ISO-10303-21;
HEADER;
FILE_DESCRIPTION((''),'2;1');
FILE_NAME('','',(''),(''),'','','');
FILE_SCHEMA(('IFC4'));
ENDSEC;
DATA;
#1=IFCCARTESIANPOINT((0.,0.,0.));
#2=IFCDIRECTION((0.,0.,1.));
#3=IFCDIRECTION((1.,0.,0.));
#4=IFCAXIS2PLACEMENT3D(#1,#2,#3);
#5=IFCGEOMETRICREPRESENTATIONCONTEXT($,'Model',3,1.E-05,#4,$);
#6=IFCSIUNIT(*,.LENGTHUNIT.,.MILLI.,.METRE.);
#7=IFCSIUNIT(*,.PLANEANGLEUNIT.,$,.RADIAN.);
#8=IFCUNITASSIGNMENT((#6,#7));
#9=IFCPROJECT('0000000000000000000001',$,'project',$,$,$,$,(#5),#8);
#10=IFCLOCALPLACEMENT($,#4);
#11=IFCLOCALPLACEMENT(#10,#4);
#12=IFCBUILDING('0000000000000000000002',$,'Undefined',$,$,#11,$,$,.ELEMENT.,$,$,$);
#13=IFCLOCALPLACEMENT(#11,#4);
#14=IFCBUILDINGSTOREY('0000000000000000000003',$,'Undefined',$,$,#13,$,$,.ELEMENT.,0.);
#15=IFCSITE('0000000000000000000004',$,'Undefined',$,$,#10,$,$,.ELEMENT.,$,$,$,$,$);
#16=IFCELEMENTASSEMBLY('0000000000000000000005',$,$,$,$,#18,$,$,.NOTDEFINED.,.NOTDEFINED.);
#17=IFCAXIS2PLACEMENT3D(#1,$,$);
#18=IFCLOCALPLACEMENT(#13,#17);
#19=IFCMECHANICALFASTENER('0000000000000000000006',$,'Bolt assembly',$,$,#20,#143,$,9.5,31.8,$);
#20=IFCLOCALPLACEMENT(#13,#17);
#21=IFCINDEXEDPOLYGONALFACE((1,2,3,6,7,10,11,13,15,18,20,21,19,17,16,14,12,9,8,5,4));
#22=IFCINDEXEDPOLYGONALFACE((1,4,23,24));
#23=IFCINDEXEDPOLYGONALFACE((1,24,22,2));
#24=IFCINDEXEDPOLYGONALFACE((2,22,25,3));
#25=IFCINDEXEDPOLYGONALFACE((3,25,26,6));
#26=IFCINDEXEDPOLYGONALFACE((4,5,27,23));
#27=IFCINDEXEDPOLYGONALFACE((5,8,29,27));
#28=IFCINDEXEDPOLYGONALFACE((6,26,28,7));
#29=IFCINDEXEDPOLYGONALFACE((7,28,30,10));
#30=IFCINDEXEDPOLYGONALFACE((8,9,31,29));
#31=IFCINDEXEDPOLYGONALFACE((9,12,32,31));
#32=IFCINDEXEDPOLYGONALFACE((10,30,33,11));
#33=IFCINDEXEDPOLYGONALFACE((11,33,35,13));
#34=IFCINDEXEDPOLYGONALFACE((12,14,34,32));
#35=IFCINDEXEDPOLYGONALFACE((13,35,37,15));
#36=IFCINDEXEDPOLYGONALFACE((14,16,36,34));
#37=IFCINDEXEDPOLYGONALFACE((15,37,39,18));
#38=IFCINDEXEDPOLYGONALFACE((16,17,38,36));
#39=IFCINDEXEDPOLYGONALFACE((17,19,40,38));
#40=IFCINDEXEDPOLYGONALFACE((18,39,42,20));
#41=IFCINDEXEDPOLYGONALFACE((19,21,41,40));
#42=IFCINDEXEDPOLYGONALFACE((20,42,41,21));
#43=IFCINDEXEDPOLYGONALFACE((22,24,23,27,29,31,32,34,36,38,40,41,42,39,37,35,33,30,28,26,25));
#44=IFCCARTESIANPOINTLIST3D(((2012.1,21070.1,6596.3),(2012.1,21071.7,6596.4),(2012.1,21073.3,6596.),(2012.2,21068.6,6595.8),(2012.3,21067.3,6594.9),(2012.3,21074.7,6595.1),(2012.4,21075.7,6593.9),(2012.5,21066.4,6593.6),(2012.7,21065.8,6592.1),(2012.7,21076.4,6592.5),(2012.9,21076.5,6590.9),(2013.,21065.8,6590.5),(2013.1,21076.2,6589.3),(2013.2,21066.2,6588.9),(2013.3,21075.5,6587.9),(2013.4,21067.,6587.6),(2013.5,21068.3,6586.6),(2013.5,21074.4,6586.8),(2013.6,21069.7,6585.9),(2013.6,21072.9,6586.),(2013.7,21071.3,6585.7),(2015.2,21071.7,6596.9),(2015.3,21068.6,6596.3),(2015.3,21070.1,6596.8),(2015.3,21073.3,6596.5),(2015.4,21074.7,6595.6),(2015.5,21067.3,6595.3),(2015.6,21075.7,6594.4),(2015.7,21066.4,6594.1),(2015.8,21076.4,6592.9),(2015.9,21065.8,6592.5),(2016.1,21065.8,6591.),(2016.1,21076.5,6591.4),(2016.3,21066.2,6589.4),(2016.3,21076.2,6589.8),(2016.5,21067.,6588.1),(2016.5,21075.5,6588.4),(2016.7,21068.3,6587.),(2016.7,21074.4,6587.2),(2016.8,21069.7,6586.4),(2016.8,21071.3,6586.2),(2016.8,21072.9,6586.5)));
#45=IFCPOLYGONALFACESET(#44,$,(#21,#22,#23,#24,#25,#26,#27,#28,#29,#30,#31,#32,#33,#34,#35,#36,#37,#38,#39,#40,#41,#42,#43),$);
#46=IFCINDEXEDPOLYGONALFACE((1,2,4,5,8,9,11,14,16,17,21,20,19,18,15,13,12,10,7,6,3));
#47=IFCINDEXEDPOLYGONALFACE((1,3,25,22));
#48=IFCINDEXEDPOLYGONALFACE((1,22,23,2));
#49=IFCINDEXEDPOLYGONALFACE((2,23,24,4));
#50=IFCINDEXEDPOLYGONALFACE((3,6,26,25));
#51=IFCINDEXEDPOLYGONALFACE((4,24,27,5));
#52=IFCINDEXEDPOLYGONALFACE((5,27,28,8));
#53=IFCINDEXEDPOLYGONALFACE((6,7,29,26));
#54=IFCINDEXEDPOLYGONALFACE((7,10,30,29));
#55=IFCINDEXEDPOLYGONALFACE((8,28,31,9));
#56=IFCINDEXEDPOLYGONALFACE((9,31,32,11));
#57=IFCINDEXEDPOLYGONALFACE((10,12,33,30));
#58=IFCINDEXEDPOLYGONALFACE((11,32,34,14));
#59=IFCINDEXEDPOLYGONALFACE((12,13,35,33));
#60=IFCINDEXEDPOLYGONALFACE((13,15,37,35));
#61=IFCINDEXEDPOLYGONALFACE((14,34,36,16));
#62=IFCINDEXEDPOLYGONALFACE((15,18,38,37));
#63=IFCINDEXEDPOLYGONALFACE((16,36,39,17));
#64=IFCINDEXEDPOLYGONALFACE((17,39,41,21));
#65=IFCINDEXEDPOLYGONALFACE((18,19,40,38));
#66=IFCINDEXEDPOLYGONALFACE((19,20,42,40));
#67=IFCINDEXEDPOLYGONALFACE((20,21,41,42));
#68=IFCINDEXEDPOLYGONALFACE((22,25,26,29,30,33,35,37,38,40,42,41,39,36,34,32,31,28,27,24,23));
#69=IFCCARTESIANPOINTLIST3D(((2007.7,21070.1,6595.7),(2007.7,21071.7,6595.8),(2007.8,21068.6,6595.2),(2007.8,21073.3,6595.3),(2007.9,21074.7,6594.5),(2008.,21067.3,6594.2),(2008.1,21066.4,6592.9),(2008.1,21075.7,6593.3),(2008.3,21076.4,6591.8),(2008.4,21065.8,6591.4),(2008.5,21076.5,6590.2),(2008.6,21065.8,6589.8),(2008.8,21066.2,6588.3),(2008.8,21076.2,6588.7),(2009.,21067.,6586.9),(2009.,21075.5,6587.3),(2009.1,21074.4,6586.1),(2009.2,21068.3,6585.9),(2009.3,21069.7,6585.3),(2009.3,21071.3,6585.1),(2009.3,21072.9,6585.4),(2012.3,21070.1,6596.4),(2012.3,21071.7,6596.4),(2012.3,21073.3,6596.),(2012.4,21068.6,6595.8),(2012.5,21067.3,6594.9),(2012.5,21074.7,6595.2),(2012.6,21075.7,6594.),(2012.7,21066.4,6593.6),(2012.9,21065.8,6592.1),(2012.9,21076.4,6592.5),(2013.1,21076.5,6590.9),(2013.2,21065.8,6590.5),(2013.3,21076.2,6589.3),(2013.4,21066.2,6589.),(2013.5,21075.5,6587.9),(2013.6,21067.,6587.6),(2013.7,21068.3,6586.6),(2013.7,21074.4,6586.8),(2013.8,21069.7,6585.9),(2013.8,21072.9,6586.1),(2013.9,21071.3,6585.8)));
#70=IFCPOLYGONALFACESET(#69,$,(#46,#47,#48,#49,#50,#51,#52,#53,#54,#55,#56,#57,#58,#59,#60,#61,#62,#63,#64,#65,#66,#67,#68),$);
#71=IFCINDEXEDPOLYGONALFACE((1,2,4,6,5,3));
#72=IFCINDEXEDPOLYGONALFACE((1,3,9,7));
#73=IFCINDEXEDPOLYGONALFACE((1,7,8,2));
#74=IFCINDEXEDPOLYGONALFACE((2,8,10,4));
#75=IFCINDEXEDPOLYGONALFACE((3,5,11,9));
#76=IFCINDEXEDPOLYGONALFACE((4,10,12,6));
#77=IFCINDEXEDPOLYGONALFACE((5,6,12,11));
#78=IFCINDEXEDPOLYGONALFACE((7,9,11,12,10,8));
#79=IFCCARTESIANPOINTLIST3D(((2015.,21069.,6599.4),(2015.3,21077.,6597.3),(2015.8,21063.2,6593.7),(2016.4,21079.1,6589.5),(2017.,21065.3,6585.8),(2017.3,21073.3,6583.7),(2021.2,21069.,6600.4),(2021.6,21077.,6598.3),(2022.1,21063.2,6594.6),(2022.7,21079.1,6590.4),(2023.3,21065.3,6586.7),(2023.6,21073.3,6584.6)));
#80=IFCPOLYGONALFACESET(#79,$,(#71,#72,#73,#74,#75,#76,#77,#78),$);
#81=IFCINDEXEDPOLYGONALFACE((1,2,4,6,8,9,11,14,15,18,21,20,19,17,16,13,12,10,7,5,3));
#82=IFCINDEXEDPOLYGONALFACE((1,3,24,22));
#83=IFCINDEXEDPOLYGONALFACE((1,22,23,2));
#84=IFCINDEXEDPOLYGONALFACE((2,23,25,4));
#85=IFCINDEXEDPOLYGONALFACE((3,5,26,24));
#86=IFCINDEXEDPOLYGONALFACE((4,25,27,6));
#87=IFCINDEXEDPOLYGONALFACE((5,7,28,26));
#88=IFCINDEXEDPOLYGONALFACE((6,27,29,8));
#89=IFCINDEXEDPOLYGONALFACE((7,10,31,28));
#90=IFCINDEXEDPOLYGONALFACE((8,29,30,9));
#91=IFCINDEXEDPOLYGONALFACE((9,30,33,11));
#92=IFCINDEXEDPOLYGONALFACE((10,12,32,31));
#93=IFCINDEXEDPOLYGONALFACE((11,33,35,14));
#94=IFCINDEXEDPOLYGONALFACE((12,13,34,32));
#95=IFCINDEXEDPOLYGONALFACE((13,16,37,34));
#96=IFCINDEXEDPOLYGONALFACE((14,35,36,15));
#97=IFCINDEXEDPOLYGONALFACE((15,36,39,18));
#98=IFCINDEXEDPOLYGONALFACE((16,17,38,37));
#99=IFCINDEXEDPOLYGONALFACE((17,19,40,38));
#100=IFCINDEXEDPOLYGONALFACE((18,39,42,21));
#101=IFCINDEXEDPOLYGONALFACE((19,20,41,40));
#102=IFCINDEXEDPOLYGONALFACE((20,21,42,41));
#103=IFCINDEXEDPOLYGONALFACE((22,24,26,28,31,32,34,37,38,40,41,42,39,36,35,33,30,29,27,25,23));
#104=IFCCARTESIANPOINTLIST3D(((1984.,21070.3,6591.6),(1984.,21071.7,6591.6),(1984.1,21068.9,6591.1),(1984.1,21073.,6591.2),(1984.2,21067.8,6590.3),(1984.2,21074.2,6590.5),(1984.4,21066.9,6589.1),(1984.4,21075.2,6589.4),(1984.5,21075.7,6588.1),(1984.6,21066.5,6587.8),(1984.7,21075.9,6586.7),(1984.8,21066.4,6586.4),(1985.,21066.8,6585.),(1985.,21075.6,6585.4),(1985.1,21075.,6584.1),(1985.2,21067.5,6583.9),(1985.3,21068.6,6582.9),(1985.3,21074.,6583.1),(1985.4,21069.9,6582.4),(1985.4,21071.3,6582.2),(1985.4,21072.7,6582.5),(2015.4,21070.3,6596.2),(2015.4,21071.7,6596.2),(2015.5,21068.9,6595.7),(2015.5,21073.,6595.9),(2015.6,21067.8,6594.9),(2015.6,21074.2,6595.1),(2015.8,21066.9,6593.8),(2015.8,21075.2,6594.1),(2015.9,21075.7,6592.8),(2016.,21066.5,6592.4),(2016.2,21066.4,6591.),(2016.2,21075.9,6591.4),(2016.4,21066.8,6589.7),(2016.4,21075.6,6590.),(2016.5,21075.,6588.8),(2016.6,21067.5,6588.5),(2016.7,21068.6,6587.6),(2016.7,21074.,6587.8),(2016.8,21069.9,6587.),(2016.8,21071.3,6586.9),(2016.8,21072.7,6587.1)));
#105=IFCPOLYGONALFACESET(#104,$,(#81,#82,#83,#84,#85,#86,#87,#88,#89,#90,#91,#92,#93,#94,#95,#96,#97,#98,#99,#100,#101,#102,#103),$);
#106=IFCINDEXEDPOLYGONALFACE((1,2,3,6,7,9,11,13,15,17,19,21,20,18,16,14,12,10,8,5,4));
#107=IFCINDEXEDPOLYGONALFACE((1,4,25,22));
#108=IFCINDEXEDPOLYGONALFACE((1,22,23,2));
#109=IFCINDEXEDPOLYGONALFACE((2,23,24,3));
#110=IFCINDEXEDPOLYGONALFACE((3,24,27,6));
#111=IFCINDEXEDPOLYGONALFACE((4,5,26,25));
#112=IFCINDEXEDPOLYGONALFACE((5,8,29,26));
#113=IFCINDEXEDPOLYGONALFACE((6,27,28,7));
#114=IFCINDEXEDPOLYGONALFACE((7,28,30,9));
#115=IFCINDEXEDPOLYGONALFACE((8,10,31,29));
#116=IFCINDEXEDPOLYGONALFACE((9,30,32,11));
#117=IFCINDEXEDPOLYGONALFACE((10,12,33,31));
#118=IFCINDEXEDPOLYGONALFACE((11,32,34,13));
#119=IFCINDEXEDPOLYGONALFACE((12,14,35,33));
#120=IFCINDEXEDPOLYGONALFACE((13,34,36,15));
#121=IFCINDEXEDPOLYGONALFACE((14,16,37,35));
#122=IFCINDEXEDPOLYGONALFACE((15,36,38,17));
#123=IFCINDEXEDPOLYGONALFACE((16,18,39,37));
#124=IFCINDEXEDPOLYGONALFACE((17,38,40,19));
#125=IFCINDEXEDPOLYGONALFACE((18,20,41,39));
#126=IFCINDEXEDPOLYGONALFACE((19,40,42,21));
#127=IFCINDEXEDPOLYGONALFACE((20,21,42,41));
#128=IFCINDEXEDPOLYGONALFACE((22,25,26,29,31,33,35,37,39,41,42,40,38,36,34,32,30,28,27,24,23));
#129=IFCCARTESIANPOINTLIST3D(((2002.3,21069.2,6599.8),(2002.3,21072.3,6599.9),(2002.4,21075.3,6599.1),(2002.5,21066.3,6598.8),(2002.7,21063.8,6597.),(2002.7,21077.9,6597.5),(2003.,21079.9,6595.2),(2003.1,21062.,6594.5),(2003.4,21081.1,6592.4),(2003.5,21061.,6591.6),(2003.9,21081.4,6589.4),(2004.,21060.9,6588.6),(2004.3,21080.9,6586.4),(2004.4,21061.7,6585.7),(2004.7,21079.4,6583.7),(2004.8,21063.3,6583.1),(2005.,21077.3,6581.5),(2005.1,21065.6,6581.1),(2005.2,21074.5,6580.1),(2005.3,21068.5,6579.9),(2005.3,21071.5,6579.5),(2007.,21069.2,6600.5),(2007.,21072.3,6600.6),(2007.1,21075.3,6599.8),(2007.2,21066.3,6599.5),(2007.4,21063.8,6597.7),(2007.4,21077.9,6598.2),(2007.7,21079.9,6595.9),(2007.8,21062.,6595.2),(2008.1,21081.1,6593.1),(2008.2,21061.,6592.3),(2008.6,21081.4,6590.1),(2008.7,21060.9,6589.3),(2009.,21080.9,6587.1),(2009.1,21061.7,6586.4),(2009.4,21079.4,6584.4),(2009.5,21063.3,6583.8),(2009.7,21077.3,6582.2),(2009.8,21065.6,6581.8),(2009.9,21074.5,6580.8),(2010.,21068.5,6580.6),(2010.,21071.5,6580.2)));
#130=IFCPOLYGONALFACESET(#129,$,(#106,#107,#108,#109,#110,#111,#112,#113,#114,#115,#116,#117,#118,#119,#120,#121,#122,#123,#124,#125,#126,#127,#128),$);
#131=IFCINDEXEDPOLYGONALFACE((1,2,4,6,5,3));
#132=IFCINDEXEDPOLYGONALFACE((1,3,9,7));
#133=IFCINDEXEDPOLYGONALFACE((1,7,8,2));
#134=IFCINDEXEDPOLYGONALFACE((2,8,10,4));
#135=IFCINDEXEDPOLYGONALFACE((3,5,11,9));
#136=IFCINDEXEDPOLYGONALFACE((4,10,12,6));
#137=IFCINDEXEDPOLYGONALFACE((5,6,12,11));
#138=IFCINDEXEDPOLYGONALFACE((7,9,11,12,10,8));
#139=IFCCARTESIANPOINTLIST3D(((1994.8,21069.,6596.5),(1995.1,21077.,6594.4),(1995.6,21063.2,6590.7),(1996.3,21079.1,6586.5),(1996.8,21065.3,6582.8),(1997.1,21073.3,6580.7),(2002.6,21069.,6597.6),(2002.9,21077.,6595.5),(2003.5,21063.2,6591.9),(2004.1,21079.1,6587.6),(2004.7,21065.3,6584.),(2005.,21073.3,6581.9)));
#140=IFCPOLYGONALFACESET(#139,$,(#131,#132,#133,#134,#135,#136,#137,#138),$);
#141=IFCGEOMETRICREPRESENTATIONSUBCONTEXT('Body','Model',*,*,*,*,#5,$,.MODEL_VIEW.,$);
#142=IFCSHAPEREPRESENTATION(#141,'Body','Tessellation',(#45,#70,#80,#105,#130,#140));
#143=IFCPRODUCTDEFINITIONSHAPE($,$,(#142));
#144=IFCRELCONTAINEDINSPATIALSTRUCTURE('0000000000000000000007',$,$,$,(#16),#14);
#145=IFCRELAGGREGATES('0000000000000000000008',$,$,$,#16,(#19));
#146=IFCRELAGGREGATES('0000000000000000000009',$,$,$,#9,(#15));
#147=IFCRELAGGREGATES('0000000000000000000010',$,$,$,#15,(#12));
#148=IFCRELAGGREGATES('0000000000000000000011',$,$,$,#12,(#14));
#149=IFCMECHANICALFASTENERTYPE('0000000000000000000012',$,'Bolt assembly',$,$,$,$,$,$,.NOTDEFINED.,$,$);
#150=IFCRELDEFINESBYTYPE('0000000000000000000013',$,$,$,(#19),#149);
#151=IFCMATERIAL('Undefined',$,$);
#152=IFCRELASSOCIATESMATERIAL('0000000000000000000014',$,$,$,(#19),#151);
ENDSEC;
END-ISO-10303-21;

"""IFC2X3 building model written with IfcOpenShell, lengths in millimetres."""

from ifc_helpers import new_model, si_unit, frame, origin_with_axes, origin_2d_with_axis, place, context, subcontext, project, spatial, polyline, circle, outline, extrude, source, transform, mapped, material, type_object, element, aggregate, save


model = new_model("IFC2X3")

# Units and contexts
model_context = context("Model", 3, precision=1e-05, world=origin_with_axes())
body_context = subcontext(model_context, "Body", "Model", "MODEL_VIEW")
ifc_project = project(units=[si_unit("LENGTHUNIT", "METRE", prefix="MILLI"), si_unit("PLANEANGLEUNIT", "RADIAN")], contexts=[model_context])

# Site, building, storey
site_placement = place(None, origin_with_axes())
site = spatial("IfcSite", under=ifc_project, at=site_placement, Name="Undefined", CompositionType="ELEMENT")
building_placement = place(site_placement, origin_with_axes())
building = spatial("IfcBuilding", under=site, at=building_placement, Name="Undefined", CompositionType="ELEMENT")
storey_placement = place(building_placement, origin_with_axes())
storey = spatial("IfcBuildingStorey", under=building, at=storey_placement, Name="Undefined", CompositionType="ELEMENT", Elevation=0.0)

# Element assembly
assembly_1_placement = place(storey_placement, origin_with_axes())
assembly_1 = element("IfcElementAssembly", 1, at=assembly_1_placement, inside=storey, AssemblyPlace="NOTDEFINED", PredefinedType="NOTDEFINED")

# Shared definitions
ifc_material_1 = material(Name="Undefined")
mechanical_fastener_type = type_object("IfcMechanicalFastenerType", Name="Bolt assembly")

# Mechanical fastener
shared_shape_1 = source(origin_with_axes(), body_context, "Body", "SweptSolid", [
    extrude(circle(Radius=5.4, at=origin_2d_with_axis()), frame((0.0, -3.1, 0.0), z_axis=(0.0, 1.0, 0.0), x_axis=(1.0, 0.0, 0.0)), (0.0, 0.0, 1.0), 3.2),
    extrude(circle(Radius=5.4, at=origin_2d_with_axis()), frame((0.0, -0.1, 0.0), z_axis=(0.0, 1.0, 0.0), x_axis=(1.0, 0.0, 0.0)), (0.0, 0.0, 1.0), 4.6),
    extrude(outline(polyline([(7.1, -4.1), (7.1, 4.1), (0.0, 8.2), (-7.1, 4.1), (-7.1, -4.1), (0.0, -8.2), (7.1, -4.1)])), frame((0.0, -9.6, 0.0), z_axis=(0.0, 1.0, 0.0), x_axis=(1.0, 0.0, 0.0)), (0.0, 0.0, 1.0), 6.3),
    extrude(circle(Radius=4.8, at=origin_2d_with_axis()), frame((0.0, -3.2, 0.0), z_axis=(0.0, 1.0, 0.0), x_axis=(1.0, 0.0, 0.0)), (0.0, 0.0, 1.0), 31.8),
    extrude(circle(Radius=10.3, at=origin_2d_with_axis()), frame((0.0, 4.5, 0.0), z_axis=(0.0, 1.0, 0.0), x_axis=(1.0, 0.0, 0.0)), (0.0, 0.0, 1.0), 4.8),
    extrude(outline(polyline([(7.1, -4.1), (7.1, 4.1), (0.0, 8.2), (-7.1, 4.1), (-7.1, -4.1), (0.0, -8.2), (7.1, -4.1)])), frame((0.0, 9.3, 0.0), z_axis=(0.0, 1.0, 0.0), x_axis=(1.0, 0.0, 0.0)), (0.0, 0.0, 1.0), 7.9),
])
mechanical_fastener_1_placement = place(assembly_1_placement, frame((2013.0, 21071.1, 6591.1), z_axis=(0.103381, -0.707107, -0.699509), x_axis=(-0.103381, -0.707107, 0.699509)))
mechanical_fastener_1 = element("IfcMechanicalFastener", 2, at=mechanical_fastener_1_placement, type_object=mechanical_fastener_type, material=ifc_material_1, Name="Bolt assembly", NominalDiameter=9.5, NominalLength=31.8, context=body_context, shape_type="MappedRepresentation", body=[
    mapped(shared_shape_1, transform((0.0, 0.0, 0.0))),
])
aggregate(assembly_1, [mechanical_fastener_1])

save(model, "model.ifc")
